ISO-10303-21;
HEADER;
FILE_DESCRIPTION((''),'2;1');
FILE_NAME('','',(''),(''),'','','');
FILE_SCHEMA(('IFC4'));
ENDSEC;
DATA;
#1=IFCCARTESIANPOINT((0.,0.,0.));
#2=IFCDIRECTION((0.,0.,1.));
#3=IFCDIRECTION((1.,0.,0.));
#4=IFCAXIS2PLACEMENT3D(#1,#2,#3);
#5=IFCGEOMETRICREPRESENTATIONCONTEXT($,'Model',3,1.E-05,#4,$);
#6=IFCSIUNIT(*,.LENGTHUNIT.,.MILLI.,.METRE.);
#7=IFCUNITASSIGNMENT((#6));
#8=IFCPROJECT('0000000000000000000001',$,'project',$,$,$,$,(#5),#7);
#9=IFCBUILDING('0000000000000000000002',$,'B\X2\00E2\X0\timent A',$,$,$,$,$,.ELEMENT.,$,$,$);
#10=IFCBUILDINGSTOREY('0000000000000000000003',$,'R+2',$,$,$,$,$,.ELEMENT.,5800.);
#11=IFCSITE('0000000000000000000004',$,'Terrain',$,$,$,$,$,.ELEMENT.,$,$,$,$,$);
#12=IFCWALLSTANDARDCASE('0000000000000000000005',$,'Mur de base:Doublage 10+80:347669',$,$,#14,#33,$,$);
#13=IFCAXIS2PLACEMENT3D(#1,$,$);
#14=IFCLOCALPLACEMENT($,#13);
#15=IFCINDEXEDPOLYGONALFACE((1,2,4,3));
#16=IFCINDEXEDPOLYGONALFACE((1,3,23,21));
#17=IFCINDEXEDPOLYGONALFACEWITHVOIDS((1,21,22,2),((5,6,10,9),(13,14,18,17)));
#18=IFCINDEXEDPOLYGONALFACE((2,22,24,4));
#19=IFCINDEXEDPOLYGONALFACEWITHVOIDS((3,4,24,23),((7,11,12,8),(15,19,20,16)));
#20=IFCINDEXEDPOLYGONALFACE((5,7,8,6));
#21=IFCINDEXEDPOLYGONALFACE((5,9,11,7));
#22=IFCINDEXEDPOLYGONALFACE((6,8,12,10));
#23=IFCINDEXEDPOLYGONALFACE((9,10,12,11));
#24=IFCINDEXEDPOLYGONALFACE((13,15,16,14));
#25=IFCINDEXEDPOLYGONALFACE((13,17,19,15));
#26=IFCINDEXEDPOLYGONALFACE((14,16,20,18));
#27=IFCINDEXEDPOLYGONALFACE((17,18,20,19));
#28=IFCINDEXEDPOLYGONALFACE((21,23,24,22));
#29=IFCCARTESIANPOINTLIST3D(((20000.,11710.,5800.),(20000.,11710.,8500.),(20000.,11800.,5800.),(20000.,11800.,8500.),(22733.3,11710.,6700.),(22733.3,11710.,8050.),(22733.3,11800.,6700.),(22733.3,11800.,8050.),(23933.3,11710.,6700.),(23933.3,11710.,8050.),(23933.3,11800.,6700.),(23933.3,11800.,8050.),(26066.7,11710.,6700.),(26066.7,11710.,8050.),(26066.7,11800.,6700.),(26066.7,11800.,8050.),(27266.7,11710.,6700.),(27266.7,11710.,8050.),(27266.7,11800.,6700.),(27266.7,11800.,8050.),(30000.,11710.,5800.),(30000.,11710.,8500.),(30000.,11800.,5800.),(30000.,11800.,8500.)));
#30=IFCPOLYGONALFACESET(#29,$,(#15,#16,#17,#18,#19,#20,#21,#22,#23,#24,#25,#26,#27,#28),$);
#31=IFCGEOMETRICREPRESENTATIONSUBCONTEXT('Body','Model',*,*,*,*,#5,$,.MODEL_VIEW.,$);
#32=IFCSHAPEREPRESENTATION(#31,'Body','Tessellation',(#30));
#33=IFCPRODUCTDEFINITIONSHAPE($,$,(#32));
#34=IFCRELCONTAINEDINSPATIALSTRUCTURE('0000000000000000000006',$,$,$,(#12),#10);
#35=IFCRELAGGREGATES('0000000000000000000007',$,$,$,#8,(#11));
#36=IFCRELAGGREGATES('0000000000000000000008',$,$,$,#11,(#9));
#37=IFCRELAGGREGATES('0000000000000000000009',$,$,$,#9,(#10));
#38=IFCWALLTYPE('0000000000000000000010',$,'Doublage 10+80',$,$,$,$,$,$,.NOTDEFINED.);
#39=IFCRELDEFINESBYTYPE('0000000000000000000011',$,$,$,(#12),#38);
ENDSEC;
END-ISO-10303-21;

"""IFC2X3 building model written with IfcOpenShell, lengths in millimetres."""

from ifc_helpers import new_model, si_unit, frame, frame_2d, origin_with_axes, place, context, subcontext, project, spatial, rectangle, extrude, type_object, element, save


model = new_model("IFC2X3")

# Units and contexts
model_context = context("Model", 3, precision=1e-05, world=origin_with_axes())
body_context = subcontext(model_context, "Body", "Model", "MODEL_VIEW")
ifc_project = project(units=[si_unit("LENGTHUNIT", "METRE", prefix="MILLI")], contexts=[model_context])

# Site, building, storey
site = spatial("IfcSite", under=ifc_project, Name="Terrain", CompositionType="ELEMENT")
building = spatial("IfcBuilding", under=site, Name="Bâtiment A", CompositionType="ELEMENT")
storey = spatial("IfcBuildingStorey", under=building, Name="R+2", CompositionType="ELEMENT", Elevation=5800.0)

# Wall, openings
wall_type_1 = type_object("IfcWallType", Name="Doublage 10+80", PredefinedType="NOTDEFINED")
wall_1_placement = place(None, origin_with_axes())
wall_1 = element("IfcWallStandardCase", 1, at=wall_1_placement, inside=storey, type_object=wall_type_1, Name="Mur de base:Doublage 10+80:347669", context=body_context, shape_type="SweptSolid", body=[
    extrude(rectangle(XDim=10000.0, YDim=90.0, at=frame_2d((25000.0, 11755.0))), frame((0.0, 0.0, 5800.0), z_axis=(0.0, 0.0, 1.0), x_axis=(1.0, 0.0, 0.0)), (0.0, 0.0, 1.0), 2700.0),
])
opening_1_placement = place(None, origin_with_axes())
element("IfcOpeningElement", 2, at=opening_1_placement, cuts=wall_1, context=body_context, shape_type="SweptSolid", body=[
    extrude(rectangle(XDim=1200.0, YDim=210.0, at=frame_2d((23333.3, 11755.0))), frame((0.0, 0.0, 6700.0), z_axis=(0.0, 0.0, 1.0), x_axis=(1.0, 0.0, 0.0)), (0.0, 0.0, 1.0), 1350.0),
])
opening_2_placement = place(None, origin_with_axes())
element("IfcOpeningElement", 3, at=opening_2_placement, cuts=wall_1, context=body_context, shape_type="SweptSolid", body=[
    extrude(rectangle(XDim=1200.0, YDim=210.0, at=frame_2d((26666.7, 11755.0))), frame((0.0, 0.0, 6700.0), z_axis=(0.0, 0.0, 1.0), x_axis=(1.0, 0.0, 0.0)), (0.0, 0.0, 1.0), 1350.0),
])

save(model, "model.ifc")
